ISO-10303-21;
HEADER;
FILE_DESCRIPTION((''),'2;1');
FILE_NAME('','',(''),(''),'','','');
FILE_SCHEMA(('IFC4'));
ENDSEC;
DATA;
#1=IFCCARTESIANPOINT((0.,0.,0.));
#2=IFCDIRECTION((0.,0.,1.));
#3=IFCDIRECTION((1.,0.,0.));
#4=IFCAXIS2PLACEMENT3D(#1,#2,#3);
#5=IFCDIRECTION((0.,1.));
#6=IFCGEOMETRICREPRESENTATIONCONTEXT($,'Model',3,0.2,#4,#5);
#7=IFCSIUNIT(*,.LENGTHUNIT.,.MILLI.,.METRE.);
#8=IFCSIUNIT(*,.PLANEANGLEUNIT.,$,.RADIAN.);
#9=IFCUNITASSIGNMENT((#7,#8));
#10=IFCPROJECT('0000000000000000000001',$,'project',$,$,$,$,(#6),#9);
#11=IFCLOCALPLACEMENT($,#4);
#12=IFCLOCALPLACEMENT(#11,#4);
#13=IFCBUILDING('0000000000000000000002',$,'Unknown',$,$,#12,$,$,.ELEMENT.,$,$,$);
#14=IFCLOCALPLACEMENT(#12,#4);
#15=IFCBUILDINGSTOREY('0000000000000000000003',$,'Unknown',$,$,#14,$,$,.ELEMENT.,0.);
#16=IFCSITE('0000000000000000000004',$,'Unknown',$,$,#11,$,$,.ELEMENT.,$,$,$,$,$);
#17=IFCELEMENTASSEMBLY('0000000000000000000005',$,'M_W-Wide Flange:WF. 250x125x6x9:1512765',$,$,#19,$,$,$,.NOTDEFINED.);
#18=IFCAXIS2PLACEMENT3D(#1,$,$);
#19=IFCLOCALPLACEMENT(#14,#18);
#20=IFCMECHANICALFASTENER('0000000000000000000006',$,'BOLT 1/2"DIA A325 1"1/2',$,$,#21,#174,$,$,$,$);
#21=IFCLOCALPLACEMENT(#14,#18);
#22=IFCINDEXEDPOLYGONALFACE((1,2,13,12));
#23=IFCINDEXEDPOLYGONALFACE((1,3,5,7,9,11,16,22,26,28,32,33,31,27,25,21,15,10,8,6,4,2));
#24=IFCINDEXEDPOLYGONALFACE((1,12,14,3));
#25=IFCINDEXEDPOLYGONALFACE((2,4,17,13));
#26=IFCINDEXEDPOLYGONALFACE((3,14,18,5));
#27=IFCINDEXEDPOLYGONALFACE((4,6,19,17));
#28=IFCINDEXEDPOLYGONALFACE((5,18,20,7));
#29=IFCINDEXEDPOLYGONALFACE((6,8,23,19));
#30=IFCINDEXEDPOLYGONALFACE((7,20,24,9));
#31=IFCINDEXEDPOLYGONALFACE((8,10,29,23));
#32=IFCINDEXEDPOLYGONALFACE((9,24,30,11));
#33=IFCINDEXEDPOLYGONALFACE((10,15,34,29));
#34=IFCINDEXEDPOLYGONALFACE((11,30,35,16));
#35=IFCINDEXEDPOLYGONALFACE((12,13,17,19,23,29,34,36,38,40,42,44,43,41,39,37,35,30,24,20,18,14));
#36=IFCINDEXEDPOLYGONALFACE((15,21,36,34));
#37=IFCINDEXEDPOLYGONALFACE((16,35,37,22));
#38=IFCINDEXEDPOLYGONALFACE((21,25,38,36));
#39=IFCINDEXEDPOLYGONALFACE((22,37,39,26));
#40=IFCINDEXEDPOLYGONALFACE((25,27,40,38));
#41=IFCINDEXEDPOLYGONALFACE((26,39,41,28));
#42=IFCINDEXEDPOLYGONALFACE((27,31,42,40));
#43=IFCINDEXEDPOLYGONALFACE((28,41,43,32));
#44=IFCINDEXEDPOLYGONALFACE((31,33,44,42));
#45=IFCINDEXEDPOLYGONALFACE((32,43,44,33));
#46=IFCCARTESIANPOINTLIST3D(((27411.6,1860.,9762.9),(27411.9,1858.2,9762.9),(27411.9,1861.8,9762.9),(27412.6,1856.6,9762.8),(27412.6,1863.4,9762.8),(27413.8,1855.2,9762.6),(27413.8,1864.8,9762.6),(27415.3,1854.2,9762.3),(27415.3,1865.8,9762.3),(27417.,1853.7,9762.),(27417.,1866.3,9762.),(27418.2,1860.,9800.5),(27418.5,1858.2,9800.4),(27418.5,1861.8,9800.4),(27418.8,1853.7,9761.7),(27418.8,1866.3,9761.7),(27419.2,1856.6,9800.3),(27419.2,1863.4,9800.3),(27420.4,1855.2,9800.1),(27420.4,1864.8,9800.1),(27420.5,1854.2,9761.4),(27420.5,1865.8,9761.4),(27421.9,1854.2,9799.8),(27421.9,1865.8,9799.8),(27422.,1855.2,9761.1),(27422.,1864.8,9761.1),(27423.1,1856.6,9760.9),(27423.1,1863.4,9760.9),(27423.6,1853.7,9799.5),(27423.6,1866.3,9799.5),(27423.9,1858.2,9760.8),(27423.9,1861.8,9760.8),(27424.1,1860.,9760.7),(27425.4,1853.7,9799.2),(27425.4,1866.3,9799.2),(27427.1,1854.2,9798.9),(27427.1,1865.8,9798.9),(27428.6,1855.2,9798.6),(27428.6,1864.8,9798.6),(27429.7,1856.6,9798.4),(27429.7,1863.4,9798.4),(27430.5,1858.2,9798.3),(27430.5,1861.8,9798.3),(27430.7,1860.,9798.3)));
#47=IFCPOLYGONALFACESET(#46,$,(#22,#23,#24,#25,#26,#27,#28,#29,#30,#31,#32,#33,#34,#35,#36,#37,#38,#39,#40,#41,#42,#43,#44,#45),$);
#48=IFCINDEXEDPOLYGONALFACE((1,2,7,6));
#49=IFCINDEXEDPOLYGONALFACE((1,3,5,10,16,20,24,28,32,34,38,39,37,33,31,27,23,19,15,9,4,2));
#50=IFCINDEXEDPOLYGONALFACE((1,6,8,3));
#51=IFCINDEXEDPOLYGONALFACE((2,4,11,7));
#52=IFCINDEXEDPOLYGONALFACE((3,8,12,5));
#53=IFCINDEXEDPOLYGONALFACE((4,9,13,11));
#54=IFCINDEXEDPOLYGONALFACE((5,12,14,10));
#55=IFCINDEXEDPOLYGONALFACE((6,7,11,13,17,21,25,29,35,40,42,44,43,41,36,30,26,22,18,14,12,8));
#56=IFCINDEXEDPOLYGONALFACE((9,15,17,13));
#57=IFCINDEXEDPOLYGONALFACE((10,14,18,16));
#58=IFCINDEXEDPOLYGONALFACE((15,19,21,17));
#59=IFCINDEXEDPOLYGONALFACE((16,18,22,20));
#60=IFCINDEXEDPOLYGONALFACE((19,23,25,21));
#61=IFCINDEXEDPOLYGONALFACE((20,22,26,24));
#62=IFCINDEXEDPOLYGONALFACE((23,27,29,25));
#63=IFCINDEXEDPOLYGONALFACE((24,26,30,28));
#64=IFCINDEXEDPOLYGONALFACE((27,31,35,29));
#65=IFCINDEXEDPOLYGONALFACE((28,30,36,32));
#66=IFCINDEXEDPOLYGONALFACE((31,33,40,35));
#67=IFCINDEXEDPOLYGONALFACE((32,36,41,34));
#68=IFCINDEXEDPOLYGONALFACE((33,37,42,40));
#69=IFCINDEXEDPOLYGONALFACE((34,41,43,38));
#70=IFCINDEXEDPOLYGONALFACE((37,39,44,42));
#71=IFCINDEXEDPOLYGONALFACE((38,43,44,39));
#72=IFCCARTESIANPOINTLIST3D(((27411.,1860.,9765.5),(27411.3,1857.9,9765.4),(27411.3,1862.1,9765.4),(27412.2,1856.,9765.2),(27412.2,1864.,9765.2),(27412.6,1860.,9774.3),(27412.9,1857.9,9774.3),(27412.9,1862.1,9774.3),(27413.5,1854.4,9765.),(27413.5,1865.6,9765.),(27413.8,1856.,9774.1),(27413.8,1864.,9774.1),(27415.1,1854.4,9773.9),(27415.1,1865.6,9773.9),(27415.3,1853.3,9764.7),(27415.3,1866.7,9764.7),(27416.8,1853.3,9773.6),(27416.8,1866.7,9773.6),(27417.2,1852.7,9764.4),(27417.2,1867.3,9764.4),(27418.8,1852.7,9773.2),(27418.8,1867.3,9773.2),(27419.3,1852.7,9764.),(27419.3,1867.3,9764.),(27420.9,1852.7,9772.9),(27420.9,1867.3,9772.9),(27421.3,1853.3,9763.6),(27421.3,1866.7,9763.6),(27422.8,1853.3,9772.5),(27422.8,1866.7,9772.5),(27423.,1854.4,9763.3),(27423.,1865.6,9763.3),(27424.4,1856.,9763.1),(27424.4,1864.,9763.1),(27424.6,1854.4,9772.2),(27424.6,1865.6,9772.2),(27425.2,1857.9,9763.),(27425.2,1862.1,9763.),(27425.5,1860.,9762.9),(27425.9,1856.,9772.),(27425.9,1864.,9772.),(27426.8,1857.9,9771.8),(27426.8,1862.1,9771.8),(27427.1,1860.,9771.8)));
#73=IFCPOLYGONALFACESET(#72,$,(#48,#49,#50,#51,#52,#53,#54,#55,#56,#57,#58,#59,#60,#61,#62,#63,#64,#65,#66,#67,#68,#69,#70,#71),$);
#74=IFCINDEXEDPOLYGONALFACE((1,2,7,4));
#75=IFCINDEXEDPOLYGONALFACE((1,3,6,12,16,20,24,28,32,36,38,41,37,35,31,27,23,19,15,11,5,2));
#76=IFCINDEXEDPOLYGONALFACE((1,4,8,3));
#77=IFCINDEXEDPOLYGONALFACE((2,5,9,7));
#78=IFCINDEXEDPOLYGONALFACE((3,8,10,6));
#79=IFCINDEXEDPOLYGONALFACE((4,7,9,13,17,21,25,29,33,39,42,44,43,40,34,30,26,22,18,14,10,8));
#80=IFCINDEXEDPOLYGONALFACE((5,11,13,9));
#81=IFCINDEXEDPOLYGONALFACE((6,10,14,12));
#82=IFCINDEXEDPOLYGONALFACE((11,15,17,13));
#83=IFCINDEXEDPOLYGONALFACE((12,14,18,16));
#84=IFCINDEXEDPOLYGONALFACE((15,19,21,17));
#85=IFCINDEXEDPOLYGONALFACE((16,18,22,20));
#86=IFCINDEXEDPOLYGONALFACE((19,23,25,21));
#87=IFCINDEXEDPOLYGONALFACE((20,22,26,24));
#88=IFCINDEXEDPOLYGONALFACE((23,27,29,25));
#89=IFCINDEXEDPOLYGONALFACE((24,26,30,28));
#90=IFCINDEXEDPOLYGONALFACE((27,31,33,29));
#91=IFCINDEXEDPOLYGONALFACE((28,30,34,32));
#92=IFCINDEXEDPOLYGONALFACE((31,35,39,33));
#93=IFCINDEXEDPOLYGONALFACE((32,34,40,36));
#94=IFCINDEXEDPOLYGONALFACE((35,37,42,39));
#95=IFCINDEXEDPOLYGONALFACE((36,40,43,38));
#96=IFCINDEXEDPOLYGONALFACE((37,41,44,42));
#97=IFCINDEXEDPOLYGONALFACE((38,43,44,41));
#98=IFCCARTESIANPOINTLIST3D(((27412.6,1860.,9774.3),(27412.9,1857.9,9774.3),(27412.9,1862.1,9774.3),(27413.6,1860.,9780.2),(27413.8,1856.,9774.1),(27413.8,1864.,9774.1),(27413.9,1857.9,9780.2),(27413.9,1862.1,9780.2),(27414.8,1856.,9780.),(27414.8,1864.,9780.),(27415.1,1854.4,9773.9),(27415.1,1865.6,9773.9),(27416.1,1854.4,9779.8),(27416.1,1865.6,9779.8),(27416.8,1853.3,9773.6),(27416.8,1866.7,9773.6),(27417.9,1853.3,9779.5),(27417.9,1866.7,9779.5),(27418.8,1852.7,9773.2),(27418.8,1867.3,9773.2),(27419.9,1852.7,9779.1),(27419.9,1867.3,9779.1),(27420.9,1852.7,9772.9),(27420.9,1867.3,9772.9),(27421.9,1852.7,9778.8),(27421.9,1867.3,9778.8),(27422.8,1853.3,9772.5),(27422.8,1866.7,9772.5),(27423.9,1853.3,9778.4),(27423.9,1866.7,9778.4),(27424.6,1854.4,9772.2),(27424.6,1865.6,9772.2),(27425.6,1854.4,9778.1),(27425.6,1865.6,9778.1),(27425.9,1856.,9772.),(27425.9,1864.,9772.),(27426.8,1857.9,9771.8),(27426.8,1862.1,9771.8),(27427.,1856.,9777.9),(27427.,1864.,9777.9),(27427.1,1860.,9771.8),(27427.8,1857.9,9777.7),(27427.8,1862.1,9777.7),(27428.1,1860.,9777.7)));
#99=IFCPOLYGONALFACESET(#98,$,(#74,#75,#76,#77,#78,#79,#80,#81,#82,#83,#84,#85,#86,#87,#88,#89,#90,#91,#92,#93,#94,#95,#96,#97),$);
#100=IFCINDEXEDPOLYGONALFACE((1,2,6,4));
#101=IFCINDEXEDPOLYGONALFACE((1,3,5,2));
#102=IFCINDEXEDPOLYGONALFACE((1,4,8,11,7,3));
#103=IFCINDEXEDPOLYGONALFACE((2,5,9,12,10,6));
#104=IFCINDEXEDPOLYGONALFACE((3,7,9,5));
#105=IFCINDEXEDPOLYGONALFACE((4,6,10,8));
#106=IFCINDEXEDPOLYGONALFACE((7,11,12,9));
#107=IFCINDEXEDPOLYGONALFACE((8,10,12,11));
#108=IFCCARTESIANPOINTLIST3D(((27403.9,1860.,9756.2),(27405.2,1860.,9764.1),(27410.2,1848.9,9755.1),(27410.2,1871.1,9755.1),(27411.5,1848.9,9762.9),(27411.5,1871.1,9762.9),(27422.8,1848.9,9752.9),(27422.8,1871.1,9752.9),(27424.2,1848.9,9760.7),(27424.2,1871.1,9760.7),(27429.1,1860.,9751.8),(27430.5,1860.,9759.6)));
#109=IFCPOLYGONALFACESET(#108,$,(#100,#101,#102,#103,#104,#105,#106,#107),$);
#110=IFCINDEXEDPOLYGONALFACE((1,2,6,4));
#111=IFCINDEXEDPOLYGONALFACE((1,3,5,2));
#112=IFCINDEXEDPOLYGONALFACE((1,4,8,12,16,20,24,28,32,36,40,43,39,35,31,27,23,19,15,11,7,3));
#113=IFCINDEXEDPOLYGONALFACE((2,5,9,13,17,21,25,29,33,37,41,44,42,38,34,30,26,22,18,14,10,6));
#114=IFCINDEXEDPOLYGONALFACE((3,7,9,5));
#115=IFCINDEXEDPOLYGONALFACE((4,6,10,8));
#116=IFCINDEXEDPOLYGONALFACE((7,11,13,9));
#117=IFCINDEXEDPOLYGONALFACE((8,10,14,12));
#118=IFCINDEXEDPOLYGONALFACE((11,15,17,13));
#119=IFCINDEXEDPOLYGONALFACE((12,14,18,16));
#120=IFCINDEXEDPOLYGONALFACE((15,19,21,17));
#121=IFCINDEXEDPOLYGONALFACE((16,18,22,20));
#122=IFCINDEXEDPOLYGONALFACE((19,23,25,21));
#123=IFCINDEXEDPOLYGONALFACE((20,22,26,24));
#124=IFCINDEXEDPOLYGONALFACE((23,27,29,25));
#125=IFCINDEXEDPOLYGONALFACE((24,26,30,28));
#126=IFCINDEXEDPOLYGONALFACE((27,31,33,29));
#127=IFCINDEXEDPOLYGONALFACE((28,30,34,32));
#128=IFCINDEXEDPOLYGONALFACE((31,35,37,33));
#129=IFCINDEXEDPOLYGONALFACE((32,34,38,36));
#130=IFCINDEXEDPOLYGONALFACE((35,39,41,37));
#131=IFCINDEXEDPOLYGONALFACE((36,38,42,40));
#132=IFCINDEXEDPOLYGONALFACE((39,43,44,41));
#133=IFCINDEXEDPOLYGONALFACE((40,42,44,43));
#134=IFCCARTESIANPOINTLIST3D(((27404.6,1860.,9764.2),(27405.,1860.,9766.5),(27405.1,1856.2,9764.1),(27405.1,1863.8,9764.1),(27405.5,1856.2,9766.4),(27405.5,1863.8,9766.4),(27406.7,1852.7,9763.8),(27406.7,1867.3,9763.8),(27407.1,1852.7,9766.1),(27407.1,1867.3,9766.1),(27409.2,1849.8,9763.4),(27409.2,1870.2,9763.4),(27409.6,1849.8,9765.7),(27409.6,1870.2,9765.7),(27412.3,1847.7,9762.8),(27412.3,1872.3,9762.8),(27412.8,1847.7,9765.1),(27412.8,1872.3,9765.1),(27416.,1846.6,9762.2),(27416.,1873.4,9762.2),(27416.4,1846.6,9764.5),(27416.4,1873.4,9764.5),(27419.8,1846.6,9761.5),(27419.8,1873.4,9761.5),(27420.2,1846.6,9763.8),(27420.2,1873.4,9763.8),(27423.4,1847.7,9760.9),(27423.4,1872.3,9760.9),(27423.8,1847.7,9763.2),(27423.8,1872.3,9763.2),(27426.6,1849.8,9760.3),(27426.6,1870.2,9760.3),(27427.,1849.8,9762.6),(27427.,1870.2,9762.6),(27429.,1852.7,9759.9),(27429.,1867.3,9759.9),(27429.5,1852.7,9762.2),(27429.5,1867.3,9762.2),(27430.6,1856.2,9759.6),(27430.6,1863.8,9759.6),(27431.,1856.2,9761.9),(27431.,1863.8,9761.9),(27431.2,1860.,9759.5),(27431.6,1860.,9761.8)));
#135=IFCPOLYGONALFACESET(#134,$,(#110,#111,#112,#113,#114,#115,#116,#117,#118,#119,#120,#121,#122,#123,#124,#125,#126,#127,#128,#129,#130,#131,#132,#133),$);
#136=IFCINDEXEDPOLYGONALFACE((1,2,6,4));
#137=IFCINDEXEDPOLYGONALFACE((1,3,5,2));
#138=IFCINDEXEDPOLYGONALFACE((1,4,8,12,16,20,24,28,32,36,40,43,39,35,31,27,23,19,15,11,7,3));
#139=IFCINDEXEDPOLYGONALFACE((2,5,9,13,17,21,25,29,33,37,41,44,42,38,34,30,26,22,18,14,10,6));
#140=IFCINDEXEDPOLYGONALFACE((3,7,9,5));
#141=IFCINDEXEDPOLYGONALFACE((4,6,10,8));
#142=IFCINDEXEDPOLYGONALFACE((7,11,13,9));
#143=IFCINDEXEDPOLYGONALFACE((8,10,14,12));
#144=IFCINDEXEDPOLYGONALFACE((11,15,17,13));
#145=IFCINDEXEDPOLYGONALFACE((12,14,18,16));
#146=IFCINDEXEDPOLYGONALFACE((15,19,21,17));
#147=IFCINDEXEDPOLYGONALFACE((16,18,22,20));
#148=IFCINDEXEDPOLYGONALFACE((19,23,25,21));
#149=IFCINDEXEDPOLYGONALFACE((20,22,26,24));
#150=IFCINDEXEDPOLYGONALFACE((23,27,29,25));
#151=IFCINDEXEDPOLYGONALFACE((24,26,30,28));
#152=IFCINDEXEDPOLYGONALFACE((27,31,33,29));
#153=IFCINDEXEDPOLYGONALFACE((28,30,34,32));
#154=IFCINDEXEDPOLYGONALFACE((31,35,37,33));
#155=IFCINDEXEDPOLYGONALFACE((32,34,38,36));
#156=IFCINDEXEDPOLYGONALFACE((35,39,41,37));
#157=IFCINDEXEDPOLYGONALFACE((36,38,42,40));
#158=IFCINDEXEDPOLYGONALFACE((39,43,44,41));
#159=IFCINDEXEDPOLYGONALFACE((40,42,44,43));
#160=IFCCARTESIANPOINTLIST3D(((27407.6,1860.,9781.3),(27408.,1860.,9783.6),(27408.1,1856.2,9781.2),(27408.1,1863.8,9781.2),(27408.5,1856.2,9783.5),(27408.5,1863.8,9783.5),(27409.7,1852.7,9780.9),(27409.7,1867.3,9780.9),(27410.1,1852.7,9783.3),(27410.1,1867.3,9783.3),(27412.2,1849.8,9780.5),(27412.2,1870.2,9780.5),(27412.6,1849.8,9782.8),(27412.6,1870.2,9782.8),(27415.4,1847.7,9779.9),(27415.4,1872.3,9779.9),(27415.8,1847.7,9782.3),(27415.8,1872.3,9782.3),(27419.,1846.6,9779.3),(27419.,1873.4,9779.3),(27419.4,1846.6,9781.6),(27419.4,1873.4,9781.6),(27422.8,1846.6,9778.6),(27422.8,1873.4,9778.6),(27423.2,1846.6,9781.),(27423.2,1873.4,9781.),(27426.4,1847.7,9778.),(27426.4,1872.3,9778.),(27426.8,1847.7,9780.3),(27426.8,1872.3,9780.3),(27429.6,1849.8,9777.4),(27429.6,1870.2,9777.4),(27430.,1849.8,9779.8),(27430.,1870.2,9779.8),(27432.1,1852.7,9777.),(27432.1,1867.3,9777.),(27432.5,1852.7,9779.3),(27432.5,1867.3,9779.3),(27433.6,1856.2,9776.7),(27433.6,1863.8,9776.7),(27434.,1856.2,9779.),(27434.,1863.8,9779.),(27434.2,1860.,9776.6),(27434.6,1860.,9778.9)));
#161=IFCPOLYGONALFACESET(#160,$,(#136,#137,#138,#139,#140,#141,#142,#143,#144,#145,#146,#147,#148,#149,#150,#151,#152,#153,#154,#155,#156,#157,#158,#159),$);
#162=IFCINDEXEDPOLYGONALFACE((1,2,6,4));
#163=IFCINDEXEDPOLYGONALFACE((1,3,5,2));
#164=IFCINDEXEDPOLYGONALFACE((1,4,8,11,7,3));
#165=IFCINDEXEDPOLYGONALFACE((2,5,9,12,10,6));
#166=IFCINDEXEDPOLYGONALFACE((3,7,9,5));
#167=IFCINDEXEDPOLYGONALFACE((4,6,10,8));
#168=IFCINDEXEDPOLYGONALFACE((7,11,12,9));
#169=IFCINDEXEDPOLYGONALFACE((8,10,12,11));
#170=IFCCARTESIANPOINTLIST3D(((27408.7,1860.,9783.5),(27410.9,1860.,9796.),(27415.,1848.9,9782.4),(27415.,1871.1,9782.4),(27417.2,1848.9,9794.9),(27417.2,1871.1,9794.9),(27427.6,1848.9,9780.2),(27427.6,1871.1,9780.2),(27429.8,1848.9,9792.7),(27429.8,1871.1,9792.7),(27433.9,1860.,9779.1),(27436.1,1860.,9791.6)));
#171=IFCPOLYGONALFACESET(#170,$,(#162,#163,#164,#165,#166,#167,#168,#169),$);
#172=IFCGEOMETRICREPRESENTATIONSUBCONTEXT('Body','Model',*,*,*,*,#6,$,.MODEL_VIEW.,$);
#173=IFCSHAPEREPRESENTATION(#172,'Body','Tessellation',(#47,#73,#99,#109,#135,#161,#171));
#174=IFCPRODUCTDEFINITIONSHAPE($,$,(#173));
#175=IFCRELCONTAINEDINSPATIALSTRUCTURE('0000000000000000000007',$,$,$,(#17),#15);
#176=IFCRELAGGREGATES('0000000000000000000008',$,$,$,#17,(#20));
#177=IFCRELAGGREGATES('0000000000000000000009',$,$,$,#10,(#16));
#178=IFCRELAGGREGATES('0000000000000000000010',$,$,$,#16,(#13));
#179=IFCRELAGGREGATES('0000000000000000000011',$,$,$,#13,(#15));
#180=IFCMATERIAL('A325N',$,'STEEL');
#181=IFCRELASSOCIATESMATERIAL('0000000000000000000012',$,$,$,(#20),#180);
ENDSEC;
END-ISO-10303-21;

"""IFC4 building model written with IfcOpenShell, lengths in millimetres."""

from ifc_helpers import new_model, si_unit, direction, frame, origin_with_axes, place, context, subcontext, project, spatial, line, arc, indexed_curve, outline, extrude, source, transform, mapped, material, element, aggregate, save


model = new_model("IFC4")

# Units and contexts
model_context = context("Model", 3, precision=0.2, world=origin_with_axes(), true_north=direction((0.0, 1.0)))
body_context = subcontext(model_context, "Body", "Model", "MODEL_VIEW")
ifc_project = project(units=[si_unit("LENGTHUNIT", "METRE", prefix="MILLI"), si_unit("PLANEANGLEUNIT", "RADIAN")], contexts=[model_context])

# Site, building, storey
site_placement = place(None, origin_with_axes())
site = spatial("IfcSite", under=ifc_project, at=site_placement, Name="Unknown", CompositionType="ELEMENT")
building_placement = place(site_placement, origin_with_axes())
building = spatial("IfcBuilding", under=site, at=building_placement, Name="Unknown", CompositionType="ELEMENT")
storey_placement = place(building_placement, origin_with_axes())
storey = spatial("IfcBuildingStorey", under=building, at=storey_placement, Name="Unknown", CompositionType="ELEMENT", Elevation=0.0)

# Element assembly, mechanical fastener
assembly_1_placement = place(storey_placement, frame((27430.1, 0.0, 9644.3), z_axis=(0.984808, 0.0, -0.173648), x_axis=(0.0, 1.0, 0.0)))
assembly_1 = element("IfcElementAssembly", 1, at=assembly_1_placement, inside=storey, Name="M_W-Wide Flange:WF. 250x125x6x9:1512765", PredefinedType="NOTDEFINED")
ifc_material_1 = material(Name="A325N", Category="STEEL")
shared_shape = source(origin_with_axes(), body_context, "Body", "SweptSolid", [
    extrude(outline(indexed_curve([(6.3, 0.0), (0.0, 6.3), (-6.3, 0.0), (0.0, -6.3)], segments=[arc(1, 2, 3), arc(3, 4, 1)])), frame((0.0, 0.0, 17.4), z_axis=(0.0, 0.0, -1.0), x_axis=(0.0, 1.0, 0.0)), (0.0, 0.0, 1.0), 38.1),
    extrude(outline(indexed_curve([(7.3, 0.0), (0.0, 7.3), (-7.3, 0.0), (0.0, -7.3)], segments=[arc(1, 2, 3), arc(3, 4, 1)])), frame((0.0, 0.0, 15.0), z_axis=(0.0, 0.0, -1.0), x_axis=(0.0, 1.0, 0.0)), (0.0, 0.0, 1.0), 9.0),
    extrude(outline(indexed_curve([(7.3, 0.0), (0.0, 7.3), (-7.3, 0.0), (0.0, -7.3)], segments=[arc(1, 2, 3), arc(3, 4, 1)])), frame((0.0, 0.0, 6.0), z_axis=(0.0, 0.0, -1.0), x_axis=(0.0, 1.0, 0.0)), (0.0, 0.0, 1.0), 6.0),
    extrude(outline(indexed_curve([(12.8, 0.0), (6.4, 11.1), (-6.4, 11.1), (-12.8, 0.0), (-6.4, -11.1), (6.4, -11.1)], segments=[line(1, 2, 3, 4, 5, 6, 1)])), frame((0.0, 0.0, 25.3), z_axis=(0.0, 0.0, -1.0), x_axis=(0.0, 1.0, 0.0)), (0.0, 0.0, 1.0), 7.9),
    extrude(outline(indexed_curve([(13.5, 0.0), (0.0, 13.5), (-13.5, 0.0), (0.0, -13.5)], segments=[arc(1, 2, 3), arc(3, 4, 1)])), frame((0.0, 0.0, 17.4), z_axis=(0.0, 0.0, -1.0), x_axis=(0.0, 1.0, 0.0)), (0.0, 0.0, 1.0), 2.4),
    extrude(outline(indexed_curve([(13.5, 0.0), (0.0, 13.5), (-13.5, 0.0), (0.0, -13.5)], segments=[arc(1, 2, 3), arc(3, 4, 1)])), frame((0.0, 0.0, 0.0), z_axis=(0.0, 0.0, -1.0), x_axis=(0.0, 1.0, 0.0)), (0.0, 0.0, 1.0), 2.4),
    extrude(outline(indexed_curve([(12.8, 0.0), (6.4, 11.1), (-6.4, 11.1), (-12.8, 0.0), (-6.4, -11.1), (6.4, -11.1)], segments=[line(1, 2, 3, 4, 5, 6, 1)])), frame((0.0, 0.0, -2.4), z_axis=(0.0, 0.0, -1.0), x_axis=(0.0, 1.0, 0.0)), (0.0, 0.0, 1.0), 12.7),
])
mechanical_fastener_1_placement = place(assembly_1_placement, frame((1860.0, 131.0, -32.5), z_axis=(0.0, -1.0, 0.0), x_axis=(1.0, 0.0, 0.0)))
mechanical_fastener_1 = element("IfcMechanicalFastener", 2, at=mechanical_fastener_1_placement, material=ifc_material_1, Name="BOLT 1/2\"DIA A325 1\"1/2", context=body_context, shape_type="MappedRepresentation", body=[
    mapped(shared_shape, transform((0.0, 0.0, 0.0))),
])
aggregate(assembly_1, [mechanical_fastener_1])

save(model, "model.ifc")
